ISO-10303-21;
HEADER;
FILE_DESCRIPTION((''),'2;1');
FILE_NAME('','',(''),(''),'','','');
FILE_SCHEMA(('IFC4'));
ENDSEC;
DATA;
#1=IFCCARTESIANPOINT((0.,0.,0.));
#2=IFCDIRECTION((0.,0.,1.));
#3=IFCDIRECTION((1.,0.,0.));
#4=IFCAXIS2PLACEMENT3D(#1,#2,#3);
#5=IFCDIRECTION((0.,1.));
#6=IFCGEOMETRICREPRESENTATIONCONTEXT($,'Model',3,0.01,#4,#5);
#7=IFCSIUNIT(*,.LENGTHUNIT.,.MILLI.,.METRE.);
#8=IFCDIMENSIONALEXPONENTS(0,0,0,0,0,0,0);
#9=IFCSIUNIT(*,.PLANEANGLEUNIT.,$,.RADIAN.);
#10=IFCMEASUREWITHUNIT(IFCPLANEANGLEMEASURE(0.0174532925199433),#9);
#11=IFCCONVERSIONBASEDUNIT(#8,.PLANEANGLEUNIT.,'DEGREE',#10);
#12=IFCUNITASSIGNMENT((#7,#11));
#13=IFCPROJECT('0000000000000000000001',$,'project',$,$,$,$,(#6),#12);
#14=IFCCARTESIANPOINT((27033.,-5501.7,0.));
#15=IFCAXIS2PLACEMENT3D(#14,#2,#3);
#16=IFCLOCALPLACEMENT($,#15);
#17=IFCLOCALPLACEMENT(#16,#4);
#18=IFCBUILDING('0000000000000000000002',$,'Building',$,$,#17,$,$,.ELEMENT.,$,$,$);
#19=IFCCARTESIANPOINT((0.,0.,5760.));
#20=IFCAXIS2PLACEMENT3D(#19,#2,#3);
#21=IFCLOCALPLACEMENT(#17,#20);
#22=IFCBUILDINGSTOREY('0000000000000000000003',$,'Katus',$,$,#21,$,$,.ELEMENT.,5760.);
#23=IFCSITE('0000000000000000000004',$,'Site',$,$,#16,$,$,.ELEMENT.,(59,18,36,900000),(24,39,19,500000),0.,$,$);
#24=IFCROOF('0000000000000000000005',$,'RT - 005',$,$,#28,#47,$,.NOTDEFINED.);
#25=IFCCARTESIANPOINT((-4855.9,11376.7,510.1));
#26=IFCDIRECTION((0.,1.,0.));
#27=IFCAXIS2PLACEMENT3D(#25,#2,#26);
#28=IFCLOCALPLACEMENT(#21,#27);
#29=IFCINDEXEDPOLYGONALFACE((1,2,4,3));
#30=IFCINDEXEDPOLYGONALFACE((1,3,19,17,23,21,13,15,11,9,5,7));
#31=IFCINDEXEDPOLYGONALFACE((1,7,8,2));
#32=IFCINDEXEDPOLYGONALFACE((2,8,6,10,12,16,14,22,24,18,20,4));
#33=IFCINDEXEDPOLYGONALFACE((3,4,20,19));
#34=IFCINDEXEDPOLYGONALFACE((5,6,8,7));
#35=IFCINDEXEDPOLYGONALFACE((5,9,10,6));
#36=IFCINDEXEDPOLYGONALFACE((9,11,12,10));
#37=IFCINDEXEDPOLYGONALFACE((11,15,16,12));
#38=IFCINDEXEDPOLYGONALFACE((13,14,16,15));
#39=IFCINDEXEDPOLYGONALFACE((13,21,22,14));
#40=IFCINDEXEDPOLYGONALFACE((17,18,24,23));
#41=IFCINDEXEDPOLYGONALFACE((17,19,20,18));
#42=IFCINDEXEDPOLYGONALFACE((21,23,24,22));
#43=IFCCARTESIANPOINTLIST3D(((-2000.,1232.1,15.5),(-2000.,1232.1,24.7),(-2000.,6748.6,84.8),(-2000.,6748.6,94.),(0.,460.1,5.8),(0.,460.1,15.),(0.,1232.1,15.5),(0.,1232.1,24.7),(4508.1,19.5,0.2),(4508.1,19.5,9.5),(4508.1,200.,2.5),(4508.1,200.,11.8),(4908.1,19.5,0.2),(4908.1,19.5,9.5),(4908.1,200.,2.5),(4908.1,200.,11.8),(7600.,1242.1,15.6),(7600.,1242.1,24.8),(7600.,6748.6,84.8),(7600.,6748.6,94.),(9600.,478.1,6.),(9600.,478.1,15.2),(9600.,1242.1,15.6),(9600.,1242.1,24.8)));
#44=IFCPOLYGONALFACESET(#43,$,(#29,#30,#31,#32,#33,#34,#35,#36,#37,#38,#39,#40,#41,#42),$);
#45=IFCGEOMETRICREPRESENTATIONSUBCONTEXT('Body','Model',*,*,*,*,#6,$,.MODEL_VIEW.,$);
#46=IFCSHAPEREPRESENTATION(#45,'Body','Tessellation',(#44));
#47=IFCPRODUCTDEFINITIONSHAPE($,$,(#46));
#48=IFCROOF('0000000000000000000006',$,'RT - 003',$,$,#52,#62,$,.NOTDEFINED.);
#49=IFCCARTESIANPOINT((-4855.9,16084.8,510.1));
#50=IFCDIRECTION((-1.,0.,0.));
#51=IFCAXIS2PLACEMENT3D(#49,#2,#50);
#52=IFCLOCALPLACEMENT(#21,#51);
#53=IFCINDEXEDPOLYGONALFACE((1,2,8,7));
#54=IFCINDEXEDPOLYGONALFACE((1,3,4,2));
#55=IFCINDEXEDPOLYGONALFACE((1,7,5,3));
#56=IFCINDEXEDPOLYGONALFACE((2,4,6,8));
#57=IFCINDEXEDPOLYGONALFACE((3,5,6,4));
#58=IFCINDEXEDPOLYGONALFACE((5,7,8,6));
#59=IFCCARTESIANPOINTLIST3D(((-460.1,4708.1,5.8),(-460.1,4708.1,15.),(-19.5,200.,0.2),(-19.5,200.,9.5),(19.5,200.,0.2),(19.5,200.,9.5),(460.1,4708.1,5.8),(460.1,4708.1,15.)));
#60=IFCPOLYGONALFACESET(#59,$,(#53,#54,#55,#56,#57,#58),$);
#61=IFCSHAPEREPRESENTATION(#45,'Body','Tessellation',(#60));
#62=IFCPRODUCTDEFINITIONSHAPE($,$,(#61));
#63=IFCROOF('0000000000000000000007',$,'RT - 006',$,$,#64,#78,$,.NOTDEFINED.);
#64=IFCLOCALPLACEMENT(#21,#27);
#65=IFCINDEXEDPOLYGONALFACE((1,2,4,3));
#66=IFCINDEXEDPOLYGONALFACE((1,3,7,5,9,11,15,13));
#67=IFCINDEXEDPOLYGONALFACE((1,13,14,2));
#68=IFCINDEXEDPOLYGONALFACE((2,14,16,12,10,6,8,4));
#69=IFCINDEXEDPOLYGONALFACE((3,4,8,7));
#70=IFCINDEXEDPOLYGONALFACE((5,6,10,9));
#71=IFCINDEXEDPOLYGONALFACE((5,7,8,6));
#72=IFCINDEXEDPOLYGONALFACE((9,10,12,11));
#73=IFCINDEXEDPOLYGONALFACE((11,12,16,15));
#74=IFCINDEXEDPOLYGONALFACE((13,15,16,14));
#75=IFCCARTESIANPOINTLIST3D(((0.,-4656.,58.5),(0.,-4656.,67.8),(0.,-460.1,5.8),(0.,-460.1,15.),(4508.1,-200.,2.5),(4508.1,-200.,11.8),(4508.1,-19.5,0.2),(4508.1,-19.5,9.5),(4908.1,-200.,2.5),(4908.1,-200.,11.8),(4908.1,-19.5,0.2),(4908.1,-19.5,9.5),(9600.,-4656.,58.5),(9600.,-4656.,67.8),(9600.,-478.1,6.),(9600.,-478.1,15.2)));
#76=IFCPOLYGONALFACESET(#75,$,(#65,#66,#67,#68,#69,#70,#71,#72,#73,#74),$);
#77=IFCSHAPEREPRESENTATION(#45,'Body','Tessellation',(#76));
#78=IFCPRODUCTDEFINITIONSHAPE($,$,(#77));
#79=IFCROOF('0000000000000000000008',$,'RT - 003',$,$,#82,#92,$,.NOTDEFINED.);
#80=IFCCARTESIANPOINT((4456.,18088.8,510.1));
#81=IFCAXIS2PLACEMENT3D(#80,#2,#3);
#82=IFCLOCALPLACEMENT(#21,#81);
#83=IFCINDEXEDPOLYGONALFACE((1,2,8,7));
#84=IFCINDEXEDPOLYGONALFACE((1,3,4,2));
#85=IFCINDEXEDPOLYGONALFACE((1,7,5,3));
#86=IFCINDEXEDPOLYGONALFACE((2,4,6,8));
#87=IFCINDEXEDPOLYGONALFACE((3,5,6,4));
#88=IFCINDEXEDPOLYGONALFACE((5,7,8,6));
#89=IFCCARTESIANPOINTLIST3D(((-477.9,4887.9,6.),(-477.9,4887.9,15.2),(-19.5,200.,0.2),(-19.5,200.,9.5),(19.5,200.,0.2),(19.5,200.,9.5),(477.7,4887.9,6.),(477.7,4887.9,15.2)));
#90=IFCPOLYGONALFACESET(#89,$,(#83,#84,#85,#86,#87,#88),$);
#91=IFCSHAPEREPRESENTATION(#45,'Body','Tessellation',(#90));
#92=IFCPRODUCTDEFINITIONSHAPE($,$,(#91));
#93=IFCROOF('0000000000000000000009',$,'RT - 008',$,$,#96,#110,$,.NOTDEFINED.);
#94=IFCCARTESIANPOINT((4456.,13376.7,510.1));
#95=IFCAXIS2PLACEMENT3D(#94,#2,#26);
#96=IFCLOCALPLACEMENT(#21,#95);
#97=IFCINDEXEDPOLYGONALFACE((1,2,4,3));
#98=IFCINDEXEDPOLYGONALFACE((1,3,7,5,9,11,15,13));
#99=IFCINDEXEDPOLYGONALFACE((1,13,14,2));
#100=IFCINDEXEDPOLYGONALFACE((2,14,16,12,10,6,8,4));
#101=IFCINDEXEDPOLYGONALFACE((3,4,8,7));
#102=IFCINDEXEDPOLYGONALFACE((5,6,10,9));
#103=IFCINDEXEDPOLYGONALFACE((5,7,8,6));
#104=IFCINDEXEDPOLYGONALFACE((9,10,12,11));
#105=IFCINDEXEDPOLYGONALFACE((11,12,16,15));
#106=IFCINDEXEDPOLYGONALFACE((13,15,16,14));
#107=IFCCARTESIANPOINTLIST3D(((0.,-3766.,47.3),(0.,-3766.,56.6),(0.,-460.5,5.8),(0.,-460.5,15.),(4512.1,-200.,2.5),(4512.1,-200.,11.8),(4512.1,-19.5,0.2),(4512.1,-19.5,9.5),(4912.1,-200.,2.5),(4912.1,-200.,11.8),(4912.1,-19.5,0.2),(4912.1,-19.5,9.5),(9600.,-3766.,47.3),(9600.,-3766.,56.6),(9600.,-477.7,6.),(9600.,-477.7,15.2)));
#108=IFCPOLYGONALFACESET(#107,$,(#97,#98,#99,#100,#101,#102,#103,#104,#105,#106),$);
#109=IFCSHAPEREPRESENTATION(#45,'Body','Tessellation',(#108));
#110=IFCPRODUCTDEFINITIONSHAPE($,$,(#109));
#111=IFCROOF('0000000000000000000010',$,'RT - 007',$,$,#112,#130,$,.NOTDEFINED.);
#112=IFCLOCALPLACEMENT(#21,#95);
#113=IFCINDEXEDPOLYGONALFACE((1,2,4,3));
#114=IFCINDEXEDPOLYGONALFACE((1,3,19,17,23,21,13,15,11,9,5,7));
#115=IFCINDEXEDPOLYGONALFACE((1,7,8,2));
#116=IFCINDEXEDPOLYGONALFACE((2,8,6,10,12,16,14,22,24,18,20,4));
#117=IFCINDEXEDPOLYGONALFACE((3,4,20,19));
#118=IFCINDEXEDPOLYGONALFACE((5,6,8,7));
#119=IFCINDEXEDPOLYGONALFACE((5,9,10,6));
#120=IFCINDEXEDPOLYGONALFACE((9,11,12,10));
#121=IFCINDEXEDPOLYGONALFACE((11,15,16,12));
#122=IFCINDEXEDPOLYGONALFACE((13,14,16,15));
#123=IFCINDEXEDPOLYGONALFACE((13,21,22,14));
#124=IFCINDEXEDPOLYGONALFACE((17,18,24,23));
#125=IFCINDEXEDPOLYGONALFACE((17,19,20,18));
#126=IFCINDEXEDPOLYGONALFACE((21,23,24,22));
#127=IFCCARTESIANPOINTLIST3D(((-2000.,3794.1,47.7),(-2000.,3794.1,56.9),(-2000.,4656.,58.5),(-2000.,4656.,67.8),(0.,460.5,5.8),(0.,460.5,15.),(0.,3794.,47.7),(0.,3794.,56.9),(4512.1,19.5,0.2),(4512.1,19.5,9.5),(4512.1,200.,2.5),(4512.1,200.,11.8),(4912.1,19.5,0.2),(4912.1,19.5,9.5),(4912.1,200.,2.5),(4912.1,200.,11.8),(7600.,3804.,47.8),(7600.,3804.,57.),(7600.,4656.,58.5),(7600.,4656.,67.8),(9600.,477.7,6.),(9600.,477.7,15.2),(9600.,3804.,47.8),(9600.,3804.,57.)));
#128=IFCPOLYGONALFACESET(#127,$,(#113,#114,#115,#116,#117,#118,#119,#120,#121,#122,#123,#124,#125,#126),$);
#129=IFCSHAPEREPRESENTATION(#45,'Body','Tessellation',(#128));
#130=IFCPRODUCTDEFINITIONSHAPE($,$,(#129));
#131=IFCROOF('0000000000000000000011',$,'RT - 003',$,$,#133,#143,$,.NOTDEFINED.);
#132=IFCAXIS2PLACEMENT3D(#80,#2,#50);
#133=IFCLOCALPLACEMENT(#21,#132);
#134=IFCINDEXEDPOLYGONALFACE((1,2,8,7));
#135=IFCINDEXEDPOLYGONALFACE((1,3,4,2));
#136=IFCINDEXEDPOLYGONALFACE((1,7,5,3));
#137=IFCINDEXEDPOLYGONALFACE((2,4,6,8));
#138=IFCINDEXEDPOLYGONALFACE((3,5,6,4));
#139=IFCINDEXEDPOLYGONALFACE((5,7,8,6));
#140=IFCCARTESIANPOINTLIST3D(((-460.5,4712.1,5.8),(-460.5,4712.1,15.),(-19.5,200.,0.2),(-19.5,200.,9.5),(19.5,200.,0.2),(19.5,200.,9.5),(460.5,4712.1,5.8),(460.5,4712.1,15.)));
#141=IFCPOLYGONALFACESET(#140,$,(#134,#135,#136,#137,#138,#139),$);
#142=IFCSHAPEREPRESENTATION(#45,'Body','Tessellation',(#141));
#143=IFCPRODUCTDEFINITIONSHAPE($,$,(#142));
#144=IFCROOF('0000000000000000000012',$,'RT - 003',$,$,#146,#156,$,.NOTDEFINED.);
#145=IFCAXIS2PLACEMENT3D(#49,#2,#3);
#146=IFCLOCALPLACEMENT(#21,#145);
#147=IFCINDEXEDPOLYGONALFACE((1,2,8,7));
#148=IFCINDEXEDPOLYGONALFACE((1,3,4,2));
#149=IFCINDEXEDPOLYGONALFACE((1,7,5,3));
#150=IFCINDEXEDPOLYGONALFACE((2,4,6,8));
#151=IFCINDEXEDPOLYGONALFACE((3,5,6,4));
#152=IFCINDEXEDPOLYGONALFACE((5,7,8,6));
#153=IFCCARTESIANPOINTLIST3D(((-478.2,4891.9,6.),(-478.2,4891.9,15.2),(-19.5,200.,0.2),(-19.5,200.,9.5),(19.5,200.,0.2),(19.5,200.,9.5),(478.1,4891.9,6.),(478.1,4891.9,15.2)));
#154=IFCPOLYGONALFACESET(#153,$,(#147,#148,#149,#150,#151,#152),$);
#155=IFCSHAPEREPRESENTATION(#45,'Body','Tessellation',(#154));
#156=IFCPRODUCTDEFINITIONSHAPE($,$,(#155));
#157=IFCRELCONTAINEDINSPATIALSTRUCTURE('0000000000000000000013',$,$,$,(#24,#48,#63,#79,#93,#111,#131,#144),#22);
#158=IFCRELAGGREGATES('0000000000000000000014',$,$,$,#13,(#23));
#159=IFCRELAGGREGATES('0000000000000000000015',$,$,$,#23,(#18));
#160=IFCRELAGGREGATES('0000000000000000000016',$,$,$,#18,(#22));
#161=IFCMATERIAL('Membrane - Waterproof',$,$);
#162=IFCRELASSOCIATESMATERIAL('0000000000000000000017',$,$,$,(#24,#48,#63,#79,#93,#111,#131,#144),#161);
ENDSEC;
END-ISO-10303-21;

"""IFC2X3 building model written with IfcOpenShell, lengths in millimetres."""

from ifc_helpers import new_model, entity, si_unit, converted_unit, direction, frame, origin_with_axes, place, context, subcontext, project, spatial, polyline, outline, extrude, material, element, save


model = new_model("IFC2X3")

# Units and contexts
model_context = context("Model", 3, precision=0.01, world=origin_with_axes(), true_north=direction((0.0, 1.0)))
body_context = subcontext(model_context, "Body", "Model", "MODEL_VIEW")
ifc_project = project(units=[si_unit("LENGTHUNIT", "METRE", prefix="MILLI"), converted_unit("PLANEANGLEUNIT", "DEGREE", entity("IfcPlaneAngleMeasure", 0.0174532925199433), si_unit("PLANEANGLEUNIT", "RADIAN"), dimensions=[0, 0, 0, 0, 0, 0, 0])], contexts=[model_context])

# Site, building, storey
site_placement = place(None, frame((27033.0, -5501.7, 0.0), z_axis=(0.0, 0.0, 1.0), x_axis=(1.0, 0.0, 0.0)))
site = spatial("IfcSite", under=ifc_project, at=site_placement, Name="Site", CompositionType="ELEMENT", RefLatitude=(59, 18, 36, 900000), RefLongitude=(24, 39, 19, 500000), RefElevation=0.0)
building_placement = place(site_placement, origin_with_axes())
building = spatial("IfcBuilding", under=site, at=building_placement, Name="Building", CompositionType="ELEMENT")
storey_placement = place(building_placement, frame((0.0, 0.0, 5760.0), z_axis=(0.0, 0.0, 1.0), x_axis=(1.0, 0.0, 0.0)))
storey = spatial("IfcBuildingStorey", under=building, at=storey_placement, Name="Katus", CompositionType="ELEMENT", Elevation=5760.0)

# Roofs
ifc_material_1 = material(Name="Membrane - Waterproof")
roof_1_placement = place(storey_placement, frame((-4855.9, 11376.7, 510.1), z_axis=(0.0, 0.0, 1.0), x_axis=(0.0, 1.0, 0.0)))
element("IfcRoof", 1, at=roof_1_placement, inside=storey, material=ifc_material_1, Name="RT - 005", ShapeType="NOTDEFINED", context=body_context, shape_type="SweptSolid", body=[
    extrude(outline(polyline([(0.0, 460.2), (4508.1, 19.5), (4508.1, 200.0), (4908.1, 200.0), (4908.1, 19.5), (9600.0, 478.1), (9600.0, 1242.2), (7600.0, 1242.2), (7600.0, 6749.1), (-2000.0, 6749.1), (-2000.0, 1232.2), (0.0, 1232.2), (0.0, 460.2)])), frame((0.0, 0.0, 0.0), z_axis=(0.0, -0.012566, 0.999921), x_axis=(1.0, 0.0, 0.0)), (0.0, 0.012566, 0.999921), 9.2),
])
roof_2_placement = place(storey_placement, frame((-4855.9, 16084.8, 510.1), z_axis=(0.0, 0.0, 1.0), x_axis=(-1.0, 0.0, 0.0)))
element("IfcRoof", 2, at=roof_2_placement, inside=storey, material=ifc_material_1, Name="RT - 003", ShapeType="NOTDEFINED", context=body_context, shape_type="SweptSolid", body=[
    extrude(outline(polyline([(19.5, 200.0), (460.1, 4708.1), (-460.1, 4708.1), (-19.5, 200.0), (19.5, 200.0)])), frame((0.0, 0.0, 0.0), z_axis=(0.0, -0.001228, 0.999999), x_axis=(1.0, 0.0, 0.0)), (0.0, 0.001228, 0.999999), 9.2),
])
roof_3_placement = place(storey_placement, frame((-4855.9, 11376.7, 510.1), z_axis=(0.0, 0.0, 1.0), x_axis=(0.0, 1.0, 0.0)))
element("IfcRoof", 3, at=roof_3_placement, inside=storey, material=ifc_material_1, Name="RT - 006", ShapeType="NOTDEFINED", context=body_context, shape_type="SweptSolid", body=[
    extrude(outline(polyline([(0.0, -460.2), (0.0, -4656.3), (9600.0, -4656.3), (9600.0, -478.1), (4908.1, -19.5), (4908.1, -200.0), (4508.1, -200.0), (4508.1, -19.5), (0.0, -460.2)])), frame((0.0, 0.0, 0.0), z_axis=(0.0, 0.012566, 0.999921), x_axis=(1.0, 0.0, 0.0)), (0.0, -0.012566, 0.999921), 9.2),
])
roof_4_placement = place(storey_placement, frame((4456.0, 18088.8, 510.1), z_axis=(0.0, 0.0, 1.0), x_axis=(1.0, 0.0, 0.0)))
element("IfcRoof", 4, at=roof_4_placement, inside=storey, material=ifc_material_1, Name="RT - 003", ShapeType="NOTDEFINED", context=body_context, shape_type="SweptSolid", body=[
    extrude(outline(polyline([(19.5, 200.0), (477.7, 4887.9), (-477.9, 4887.9), (-19.5, 200.0), (19.5, 200.0)])), frame((0.0, 0.0, 0.0), z_axis=(0.0, -0.001228, 0.999999), x_axis=(1.0, 0.0, 0.0)), (0.0, 0.001228, 0.999999), 9.2),
])
roof_5_placement = place(storey_placement, frame((4456.0, 13376.7, 510.1), z_axis=(0.0, 0.0, 1.0), x_axis=(0.0, 1.0, 0.0)))
element("IfcRoof", 5, at=roof_5_placement, inside=storey, material=ifc_material_1, Name="RT - 008", ShapeType="NOTDEFINED", context=body_context, shape_type="SweptSolid", body=[
    extrude(outline(polyline([(9600.0, -477.7), (4912.1, -19.5), (4912.1, -200.0), (4512.1, -200.0), (4512.1, -19.5), (0.0, -460.5), (0.0, -3766.3), (9600.0, -3766.3), (9600.0, -477.7)])), frame((0.0, 0.0, 0.0), z_axis=(0.0, 0.012566, 0.999921), x_axis=(1.0, 0.0, 0.0)), (0.0, -0.012566, 0.999921), 9.2),
])
roof_6_placement = place(storey_placement, frame((4456.0, 13376.7, 510.1), z_axis=(0.0, 0.0, 1.0), x_axis=(0.0, 1.0, 0.0)))
element("IfcRoof", 6, at=roof_6_placement, inside=storey, material=ifc_material_1, Name="RT - 007", ShapeType="NOTDEFINED", context=body_context, shape_type="SweptSolid", body=[
    extrude(outline(polyline([(9600.0, 477.7), (9600.0, 3804.3), (7600.0, 3804.3), (7600.0, 4656.3), (-2000.0, 4656.3), (-2000.0, 3794.4), (0.0, 3794.3), (0.0, 460.5), (4512.1, 19.5), (4512.1, 200.0), (4912.1, 200.0), (4912.1, 19.5), (9600.0, 477.7)])), frame((0.0, 0.0, 0.0), z_axis=(0.0, -0.012566, 0.999921), x_axis=(1.0, 0.0, 0.0)), (0.0, 0.012566, 0.999921), 9.2),
])
roof_7_placement = place(storey_placement, frame((4456.0, 18088.8, 510.1), z_axis=(0.0, 0.0, 1.0), x_axis=(-1.0, 0.0, 0.0)))
element("IfcRoof", 7, at=roof_7_placement, inside=storey, material=ifc_material_1, Name="RT - 003", ShapeType="NOTDEFINED", context=body_context, shape_type="SweptSolid", body=[
    extrude(outline(polyline([(19.5, 200.0), (460.5, 4712.1), (-460.5, 4712.1), (-19.5, 200.0), (19.5, 200.0)])), frame((0.0, 0.0, 0.0), z_axis=(0.0, -0.001228, 0.999999), x_axis=(1.0, 0.0, 0.0)), (0.0, 0.001228, 0.999999), 9.2),
])
roof_8_placement = place(storey_placement, frame((-4855.9, 16084.8, 510.1), z_axis=(0.0, 0.0, 1.0), x_axis=(1.0, 0.0, 0.0)))
element("IfcRoof", 8, at=roof_8_placement, inside=storey, material=ifc_material_1, Name="RT - 003", ShapeType="NOTDEFINED", context=body_context, shape_type="SweptSolid", body=[
    extrude(outline(polyline([(19.5, 200.0), (478.1, 4891.9), (-478.2, 4891.9), (-19.5, 200.0), (19.5, 200.0)])), frame((0.0, 0.0, 0.0), z_axis=(0.0, -0.001228, 0.999999), x_axis=(1.0, 0.0, 0.0)), (0.0, 0.001228, 0.999999), 9.2),
])

save(model, "model.ifc")
